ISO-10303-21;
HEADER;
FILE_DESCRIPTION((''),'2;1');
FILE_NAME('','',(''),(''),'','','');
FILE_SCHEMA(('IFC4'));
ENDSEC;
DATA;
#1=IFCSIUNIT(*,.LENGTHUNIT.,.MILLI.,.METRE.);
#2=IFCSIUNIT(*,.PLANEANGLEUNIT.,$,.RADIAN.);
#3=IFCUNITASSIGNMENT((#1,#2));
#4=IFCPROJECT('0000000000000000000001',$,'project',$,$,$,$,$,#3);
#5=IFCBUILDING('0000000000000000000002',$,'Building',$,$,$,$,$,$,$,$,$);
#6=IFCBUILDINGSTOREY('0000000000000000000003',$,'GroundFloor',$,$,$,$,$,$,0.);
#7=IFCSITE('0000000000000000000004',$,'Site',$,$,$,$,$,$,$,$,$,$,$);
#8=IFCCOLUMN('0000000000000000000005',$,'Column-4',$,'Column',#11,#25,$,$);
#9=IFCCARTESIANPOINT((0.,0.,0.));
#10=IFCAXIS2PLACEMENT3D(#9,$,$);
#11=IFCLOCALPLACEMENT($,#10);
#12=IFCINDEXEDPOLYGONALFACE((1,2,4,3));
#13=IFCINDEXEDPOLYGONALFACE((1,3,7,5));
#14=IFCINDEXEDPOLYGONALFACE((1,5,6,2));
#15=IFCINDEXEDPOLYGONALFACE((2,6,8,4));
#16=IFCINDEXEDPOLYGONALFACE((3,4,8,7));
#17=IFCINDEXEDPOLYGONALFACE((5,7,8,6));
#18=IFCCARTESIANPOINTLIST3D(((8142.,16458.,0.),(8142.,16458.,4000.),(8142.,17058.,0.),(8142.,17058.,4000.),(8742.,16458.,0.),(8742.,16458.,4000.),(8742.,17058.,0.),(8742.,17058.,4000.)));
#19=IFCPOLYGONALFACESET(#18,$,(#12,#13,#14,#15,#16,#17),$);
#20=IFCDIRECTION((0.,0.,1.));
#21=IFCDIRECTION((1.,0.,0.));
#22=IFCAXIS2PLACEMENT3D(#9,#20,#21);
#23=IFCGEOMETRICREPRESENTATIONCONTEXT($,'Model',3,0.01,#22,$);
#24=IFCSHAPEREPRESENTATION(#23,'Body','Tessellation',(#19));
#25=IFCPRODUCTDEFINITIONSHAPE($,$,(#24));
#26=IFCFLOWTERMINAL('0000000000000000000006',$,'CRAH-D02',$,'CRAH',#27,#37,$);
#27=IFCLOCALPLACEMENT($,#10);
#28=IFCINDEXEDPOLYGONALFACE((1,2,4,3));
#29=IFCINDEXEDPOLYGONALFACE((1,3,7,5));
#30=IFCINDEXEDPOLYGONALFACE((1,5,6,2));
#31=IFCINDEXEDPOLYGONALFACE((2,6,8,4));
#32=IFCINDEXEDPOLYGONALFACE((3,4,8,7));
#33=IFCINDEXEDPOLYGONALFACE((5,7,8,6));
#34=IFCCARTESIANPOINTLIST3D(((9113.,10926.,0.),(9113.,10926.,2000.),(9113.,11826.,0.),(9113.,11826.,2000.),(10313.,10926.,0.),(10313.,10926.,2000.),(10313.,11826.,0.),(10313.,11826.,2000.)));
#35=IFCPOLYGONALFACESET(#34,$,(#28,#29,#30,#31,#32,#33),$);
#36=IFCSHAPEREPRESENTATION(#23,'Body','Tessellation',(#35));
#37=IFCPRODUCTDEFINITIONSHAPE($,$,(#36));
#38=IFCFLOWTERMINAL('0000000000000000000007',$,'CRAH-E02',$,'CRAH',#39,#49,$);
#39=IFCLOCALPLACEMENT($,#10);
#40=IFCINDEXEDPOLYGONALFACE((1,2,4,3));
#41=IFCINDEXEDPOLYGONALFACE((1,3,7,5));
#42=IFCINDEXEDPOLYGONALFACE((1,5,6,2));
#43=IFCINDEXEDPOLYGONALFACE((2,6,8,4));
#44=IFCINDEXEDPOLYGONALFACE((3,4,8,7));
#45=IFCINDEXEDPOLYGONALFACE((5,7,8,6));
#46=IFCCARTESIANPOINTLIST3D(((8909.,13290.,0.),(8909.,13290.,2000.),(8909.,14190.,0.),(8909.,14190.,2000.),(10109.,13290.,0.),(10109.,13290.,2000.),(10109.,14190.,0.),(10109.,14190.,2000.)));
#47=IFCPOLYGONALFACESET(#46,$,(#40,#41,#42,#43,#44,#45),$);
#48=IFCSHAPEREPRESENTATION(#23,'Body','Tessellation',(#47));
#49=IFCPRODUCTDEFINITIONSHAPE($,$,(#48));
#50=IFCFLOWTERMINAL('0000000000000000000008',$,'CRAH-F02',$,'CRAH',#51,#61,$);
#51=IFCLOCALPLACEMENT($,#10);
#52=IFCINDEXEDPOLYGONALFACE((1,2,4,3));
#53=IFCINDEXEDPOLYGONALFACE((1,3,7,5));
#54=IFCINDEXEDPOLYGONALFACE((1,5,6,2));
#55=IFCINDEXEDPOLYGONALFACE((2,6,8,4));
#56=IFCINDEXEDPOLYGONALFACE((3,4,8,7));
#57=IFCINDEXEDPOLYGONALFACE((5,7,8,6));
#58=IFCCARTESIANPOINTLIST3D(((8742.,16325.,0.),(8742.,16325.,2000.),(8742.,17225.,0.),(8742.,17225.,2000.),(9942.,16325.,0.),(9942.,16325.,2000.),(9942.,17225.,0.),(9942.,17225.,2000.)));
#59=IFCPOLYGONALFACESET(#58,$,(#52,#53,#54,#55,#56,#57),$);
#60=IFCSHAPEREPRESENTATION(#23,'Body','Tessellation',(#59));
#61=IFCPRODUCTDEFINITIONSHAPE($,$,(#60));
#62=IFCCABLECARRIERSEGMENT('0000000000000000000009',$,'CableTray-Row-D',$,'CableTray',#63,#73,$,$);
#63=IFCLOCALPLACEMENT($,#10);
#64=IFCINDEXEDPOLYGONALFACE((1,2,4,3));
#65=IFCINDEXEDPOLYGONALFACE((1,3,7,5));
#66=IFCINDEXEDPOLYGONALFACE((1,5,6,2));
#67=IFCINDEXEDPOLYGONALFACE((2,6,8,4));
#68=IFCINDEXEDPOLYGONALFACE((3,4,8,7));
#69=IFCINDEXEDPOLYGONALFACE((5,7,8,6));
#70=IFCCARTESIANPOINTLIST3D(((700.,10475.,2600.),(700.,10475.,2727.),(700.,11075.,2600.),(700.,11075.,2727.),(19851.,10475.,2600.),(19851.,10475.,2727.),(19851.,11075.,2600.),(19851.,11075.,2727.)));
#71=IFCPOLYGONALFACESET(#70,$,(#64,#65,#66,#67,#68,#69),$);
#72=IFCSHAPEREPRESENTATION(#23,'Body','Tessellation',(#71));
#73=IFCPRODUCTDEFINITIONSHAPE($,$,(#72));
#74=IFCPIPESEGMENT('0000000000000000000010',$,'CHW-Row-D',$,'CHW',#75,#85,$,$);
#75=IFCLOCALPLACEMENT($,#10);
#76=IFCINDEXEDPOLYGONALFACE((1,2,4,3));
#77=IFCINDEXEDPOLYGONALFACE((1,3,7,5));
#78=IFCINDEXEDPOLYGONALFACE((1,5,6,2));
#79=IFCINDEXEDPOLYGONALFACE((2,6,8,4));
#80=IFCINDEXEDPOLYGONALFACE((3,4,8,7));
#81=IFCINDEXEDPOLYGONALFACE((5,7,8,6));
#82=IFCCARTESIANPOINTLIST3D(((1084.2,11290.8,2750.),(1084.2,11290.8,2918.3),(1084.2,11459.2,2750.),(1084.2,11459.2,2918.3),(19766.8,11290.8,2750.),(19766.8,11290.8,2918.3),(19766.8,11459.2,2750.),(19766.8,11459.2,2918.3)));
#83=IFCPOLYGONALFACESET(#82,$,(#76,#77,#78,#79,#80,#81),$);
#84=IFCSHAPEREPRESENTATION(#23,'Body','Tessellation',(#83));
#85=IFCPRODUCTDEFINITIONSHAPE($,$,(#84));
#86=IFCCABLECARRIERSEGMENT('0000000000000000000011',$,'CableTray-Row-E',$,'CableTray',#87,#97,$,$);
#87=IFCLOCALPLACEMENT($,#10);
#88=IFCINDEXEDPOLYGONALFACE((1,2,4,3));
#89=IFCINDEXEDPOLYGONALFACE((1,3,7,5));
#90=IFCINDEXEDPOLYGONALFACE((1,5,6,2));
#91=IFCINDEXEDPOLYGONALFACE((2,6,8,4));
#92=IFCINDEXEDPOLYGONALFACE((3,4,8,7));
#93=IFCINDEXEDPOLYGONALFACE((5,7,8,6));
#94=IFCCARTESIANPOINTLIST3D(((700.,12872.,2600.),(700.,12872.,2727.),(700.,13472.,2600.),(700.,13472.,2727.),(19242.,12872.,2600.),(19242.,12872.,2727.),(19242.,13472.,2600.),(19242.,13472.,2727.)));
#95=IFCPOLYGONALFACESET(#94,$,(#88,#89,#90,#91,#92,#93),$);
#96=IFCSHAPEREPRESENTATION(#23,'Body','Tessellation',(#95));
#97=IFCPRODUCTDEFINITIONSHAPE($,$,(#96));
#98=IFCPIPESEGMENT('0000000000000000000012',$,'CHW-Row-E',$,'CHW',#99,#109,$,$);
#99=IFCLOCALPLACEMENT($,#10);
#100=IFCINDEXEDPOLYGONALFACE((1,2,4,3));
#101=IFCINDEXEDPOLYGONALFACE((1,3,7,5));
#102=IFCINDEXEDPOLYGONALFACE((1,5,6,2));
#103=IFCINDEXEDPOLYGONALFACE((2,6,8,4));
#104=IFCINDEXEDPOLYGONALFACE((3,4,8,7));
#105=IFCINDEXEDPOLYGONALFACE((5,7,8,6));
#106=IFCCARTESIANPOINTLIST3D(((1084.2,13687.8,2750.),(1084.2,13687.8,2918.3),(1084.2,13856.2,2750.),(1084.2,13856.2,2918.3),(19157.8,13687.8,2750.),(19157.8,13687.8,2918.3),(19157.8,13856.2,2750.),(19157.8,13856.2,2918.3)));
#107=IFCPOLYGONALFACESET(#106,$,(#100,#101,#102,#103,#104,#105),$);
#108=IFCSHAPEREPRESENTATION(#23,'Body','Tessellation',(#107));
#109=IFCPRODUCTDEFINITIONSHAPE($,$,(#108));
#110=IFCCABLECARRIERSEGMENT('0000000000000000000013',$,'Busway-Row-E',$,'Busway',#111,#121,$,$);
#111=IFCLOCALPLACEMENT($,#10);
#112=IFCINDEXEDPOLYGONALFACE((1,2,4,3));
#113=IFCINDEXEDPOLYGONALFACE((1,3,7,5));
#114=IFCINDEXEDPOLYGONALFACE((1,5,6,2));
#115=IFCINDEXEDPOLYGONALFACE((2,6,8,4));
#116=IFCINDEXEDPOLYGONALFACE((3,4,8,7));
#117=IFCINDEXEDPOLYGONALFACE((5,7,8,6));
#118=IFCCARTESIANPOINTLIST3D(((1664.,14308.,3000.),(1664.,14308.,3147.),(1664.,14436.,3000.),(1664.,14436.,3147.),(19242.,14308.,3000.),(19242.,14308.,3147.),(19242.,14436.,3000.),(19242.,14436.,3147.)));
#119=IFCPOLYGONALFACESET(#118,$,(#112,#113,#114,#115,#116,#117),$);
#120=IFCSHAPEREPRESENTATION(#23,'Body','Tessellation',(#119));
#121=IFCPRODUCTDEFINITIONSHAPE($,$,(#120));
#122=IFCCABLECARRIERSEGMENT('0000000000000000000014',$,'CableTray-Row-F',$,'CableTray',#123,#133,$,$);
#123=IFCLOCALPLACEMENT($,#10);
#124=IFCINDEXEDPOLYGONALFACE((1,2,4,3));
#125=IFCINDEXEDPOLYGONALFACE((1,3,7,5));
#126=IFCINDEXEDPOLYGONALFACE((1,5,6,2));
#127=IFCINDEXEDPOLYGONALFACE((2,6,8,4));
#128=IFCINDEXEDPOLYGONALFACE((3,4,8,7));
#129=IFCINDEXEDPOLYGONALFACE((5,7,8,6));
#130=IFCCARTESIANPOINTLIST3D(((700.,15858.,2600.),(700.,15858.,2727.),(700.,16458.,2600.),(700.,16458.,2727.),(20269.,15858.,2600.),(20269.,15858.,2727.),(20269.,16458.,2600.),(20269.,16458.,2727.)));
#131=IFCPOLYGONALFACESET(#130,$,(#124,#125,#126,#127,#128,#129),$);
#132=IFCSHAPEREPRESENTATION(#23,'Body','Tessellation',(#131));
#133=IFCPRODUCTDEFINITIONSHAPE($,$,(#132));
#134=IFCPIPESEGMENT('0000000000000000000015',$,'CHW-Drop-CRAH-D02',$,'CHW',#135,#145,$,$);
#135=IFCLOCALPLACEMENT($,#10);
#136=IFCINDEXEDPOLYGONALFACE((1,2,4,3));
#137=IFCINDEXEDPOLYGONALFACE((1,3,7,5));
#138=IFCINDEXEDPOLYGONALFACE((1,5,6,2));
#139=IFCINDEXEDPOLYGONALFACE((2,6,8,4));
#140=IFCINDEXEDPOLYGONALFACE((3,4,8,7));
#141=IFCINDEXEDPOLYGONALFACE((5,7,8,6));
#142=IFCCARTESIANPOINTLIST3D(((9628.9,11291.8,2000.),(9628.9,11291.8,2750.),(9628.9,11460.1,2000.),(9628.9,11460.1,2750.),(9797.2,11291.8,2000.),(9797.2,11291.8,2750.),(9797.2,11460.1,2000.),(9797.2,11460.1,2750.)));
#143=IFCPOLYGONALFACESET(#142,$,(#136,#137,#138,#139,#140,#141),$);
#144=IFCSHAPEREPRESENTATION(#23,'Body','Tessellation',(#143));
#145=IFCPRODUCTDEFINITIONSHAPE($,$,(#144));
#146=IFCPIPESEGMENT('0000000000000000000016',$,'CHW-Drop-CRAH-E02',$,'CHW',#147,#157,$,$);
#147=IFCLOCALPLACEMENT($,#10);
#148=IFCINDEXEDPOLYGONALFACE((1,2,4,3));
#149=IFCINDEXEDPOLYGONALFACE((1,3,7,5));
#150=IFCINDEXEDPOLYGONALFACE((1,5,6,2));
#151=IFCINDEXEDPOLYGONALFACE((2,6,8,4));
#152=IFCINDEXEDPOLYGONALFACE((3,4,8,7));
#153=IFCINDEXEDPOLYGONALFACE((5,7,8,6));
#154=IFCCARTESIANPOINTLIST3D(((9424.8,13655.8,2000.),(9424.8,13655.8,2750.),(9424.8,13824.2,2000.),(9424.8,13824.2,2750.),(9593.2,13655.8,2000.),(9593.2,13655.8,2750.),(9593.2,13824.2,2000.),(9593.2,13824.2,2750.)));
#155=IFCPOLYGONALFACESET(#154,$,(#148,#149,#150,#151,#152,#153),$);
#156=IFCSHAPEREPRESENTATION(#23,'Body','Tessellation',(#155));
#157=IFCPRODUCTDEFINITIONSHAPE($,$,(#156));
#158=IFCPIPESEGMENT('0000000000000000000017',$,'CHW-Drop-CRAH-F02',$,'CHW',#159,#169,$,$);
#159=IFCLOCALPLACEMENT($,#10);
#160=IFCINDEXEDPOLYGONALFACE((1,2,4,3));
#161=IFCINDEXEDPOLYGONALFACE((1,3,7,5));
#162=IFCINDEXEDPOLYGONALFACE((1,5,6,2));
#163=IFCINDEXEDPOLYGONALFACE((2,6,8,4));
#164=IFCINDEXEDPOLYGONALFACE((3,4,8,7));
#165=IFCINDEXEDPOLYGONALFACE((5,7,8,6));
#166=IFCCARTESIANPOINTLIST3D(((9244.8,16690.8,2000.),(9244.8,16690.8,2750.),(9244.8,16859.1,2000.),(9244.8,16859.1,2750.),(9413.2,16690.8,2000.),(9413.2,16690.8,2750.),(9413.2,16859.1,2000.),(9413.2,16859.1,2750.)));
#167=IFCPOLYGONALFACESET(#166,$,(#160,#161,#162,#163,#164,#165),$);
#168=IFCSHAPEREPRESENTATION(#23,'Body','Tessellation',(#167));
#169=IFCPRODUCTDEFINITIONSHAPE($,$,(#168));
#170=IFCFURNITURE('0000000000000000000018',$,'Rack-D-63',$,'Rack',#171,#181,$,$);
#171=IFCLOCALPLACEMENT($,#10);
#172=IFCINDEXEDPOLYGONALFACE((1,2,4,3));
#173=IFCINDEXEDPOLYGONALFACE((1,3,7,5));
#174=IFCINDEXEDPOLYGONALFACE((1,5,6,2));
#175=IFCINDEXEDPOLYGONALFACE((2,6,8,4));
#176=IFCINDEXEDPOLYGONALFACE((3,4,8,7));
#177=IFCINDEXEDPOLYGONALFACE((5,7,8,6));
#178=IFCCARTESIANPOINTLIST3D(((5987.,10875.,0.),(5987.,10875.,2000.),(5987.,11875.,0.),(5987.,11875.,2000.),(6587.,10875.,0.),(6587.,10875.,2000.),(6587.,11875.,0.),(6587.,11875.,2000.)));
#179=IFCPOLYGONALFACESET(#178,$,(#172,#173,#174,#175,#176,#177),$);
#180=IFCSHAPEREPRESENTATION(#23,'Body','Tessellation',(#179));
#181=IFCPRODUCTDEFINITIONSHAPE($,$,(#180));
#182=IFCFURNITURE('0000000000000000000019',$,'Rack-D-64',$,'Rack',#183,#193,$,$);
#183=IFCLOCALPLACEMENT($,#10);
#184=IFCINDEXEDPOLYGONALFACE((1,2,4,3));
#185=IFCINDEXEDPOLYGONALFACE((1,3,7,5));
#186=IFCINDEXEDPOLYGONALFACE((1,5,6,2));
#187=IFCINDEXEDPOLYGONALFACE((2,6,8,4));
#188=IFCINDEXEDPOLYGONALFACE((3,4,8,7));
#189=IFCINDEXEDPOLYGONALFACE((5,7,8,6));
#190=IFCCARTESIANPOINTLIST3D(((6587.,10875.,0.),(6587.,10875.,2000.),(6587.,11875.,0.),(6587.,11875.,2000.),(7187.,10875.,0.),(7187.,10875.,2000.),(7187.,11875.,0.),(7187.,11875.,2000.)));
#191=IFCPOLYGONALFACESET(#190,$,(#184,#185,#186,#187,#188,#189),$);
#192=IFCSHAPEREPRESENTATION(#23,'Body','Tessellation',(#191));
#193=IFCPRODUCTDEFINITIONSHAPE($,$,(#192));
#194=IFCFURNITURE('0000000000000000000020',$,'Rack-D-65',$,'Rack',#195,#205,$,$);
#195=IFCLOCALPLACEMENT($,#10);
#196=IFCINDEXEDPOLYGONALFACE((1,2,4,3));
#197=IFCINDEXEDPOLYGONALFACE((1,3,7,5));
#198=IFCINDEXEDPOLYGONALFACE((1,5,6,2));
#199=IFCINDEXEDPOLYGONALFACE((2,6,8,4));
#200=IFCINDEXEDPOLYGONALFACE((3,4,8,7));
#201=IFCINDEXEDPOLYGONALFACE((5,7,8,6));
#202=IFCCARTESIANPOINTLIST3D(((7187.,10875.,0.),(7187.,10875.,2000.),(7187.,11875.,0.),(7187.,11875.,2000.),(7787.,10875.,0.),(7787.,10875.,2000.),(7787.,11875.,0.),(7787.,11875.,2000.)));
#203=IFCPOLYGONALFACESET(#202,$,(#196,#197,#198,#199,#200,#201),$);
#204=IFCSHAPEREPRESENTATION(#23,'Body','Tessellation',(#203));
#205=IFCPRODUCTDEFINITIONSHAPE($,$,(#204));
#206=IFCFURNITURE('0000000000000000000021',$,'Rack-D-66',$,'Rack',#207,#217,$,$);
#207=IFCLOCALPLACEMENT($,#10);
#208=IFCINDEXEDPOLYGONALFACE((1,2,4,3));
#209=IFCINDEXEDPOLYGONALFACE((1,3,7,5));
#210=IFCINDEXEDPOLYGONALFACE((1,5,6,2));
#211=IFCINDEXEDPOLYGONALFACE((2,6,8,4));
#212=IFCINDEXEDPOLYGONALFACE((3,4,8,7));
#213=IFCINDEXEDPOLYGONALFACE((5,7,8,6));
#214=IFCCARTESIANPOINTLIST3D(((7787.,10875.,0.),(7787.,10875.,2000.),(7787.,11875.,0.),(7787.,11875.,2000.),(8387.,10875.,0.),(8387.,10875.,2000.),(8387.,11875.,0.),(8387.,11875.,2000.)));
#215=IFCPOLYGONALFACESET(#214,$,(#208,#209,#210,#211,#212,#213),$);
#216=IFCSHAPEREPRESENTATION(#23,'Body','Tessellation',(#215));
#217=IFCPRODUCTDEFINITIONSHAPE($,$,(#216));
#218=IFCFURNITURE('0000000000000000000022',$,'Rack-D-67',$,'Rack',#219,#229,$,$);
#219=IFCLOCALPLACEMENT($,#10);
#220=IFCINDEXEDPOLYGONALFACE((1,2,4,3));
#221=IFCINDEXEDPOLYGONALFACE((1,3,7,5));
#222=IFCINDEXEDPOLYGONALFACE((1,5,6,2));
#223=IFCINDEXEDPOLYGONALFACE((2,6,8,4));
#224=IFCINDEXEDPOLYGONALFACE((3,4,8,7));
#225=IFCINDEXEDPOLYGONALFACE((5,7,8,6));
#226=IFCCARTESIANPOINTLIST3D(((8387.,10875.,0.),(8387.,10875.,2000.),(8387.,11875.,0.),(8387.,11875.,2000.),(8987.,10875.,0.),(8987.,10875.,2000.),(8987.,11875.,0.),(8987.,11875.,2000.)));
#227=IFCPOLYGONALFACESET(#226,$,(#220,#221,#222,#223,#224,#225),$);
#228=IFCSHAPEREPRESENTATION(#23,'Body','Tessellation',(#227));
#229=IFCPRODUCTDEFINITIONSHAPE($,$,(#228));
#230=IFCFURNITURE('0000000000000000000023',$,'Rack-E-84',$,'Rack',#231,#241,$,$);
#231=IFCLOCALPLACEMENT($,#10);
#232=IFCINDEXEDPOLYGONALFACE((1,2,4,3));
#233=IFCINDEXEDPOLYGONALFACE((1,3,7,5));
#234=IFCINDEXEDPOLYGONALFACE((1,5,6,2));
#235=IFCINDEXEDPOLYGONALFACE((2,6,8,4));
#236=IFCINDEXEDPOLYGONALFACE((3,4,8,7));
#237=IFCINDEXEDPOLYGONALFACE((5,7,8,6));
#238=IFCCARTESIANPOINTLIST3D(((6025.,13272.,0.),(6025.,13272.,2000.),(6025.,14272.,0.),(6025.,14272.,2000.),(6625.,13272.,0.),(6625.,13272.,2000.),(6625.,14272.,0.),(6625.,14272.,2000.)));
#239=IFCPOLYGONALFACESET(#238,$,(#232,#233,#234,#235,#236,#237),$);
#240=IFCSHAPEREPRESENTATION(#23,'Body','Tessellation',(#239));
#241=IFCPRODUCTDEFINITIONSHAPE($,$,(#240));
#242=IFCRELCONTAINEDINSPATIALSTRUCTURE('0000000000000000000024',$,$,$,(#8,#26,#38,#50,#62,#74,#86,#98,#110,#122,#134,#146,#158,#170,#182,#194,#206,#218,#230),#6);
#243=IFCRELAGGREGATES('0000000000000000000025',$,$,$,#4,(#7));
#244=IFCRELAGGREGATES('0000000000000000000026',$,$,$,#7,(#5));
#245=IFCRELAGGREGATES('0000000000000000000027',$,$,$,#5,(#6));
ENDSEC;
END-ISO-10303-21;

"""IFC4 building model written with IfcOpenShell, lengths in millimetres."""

from ifc_helpers import new_model, si_unit, frame, origin, origin_with_axes, origin_2d, place, context, project, spatial, rectangle, extrude, element, save


model = new_model("IFC4")

# Units and contexts
model_context = context("Model", 3, precision=0.01, world=origin_with_axes())
ifc_project = project(units=[si_unit("LENGTHUNIT", "METRE", prefix="MILLI"), si_unit("PLANEANGLEUNIT", "RADIAN")])

# Site, building, storey
site = spatial("IfcSite", under=ifc_project, Name="Site")
building = spatial("IfcBuilding", under=site, Name="Building")
storey = spatial("IfcBuildingStorey", under=building, Name="GroundFloor", Elevation=0.0)

# Column
column_placement = place(None, frame((8442.0, 16758.0, 0.0), z_axis=(0.0, 0.0, 1.0), x_axis=(1.0, 0.0, 0.0)))
element("IfcColumn", 1, at=column_placement, inside=storey, Name="Column-4", ObjectType="Column", context=model_context, shape_type="SweptSolid", body=[
    extrude(rectangle(XDim=600.0, YDim=600.0, at=origin_2d()), origin(), (0.0, 0.0, 1.0), 4000.0),
])

# Flow terminals
for number, where, z_axis, x_axis, name in (
    (2, (9713.0, 11376.0, 0.0), (0.0, 0.0, 1.0), (1.0, 0.0, 0.0), "CRAH-D02"),
    (3, (9509.0, 13740.0, 0.0), (0.0, 0.0, 1.0), (1.0, 0.0, 0.0), "CRAH-E02"),
    (4, (9342.0, 16775.0, 0.0), (0.0, 0.0, 1.0), (1.0, 0.0, 0.0), "CRAH-F02"),
):
    element("IfcFlowTerminal", number, at=place(None, frame(where, z_axis=z_axis, x_axis=x_axis)), inside=storey, Name=name, ObjectType="CRAH", context=model_context, shape_type="SweptSolid", body=[
        extrude(rectangle(XDim=1200.0, YDim=900.0, at=origin_2d()), origin(), (0.0, 0.0, 1.0), 2000.0),
    ])

# Cable carrier segment
cable_carrier_segment_1_placement = place(None, frame((10275.5, 10775.0, 2600.0), z_axis=(0.0, 0.0, 1.0), x_axis=(1.0, 0.0, 0.0)))
element("IfcCableCarrierSegment", 5, at=cable_carrier_segment_1_placement, inside=storey, Name="CableTray-Row-D", ObjectType="CableTray", context=model_context, shape_type="SweptSolid", body=[
    extrude(rectangle(XDim=19151.0, YDim=600.0, at=origin_2d()), origin(), (0.0, 0.0, 1.0), 127.0),
])

# Pipe segment
pipe_segment_1_placement = place(None, frame((10425.5, 11375.0, 2750.0), z_axis=(0.0, 0.0, 1.0), x_axis=(1.0, 0.0, 0.0)))
element("IfcPipeSegment", 6, at=pipe_segment_1_placement, inside=storey, Name="CHW-Row-D", ObjectType="CHW", context=model_context, shape_type="SweptSolid", body=[
    extrude(rectangle(XDim=18682.7, YDim=168.3, at=origin_2d()), origin(), (0.0, 0.0, 1.0), 168.3),
])

# Cable carrier segment
cable_carrier_segment_2_placement = place(None, frame((9971.0, 13172.0, 2600.0), z_axis=(0.0, 0.0, 1.0), x_axis=(1.0, 0.0, 0.0)))
element("IfcCableCarrierSegment", 7, at=cable_carrier_segment_2_placement, inside=storey, Name="CableTray-Row-E", ObjectType="CableTray", context=model_context, shape_type="SweptSolid", body=[
    extrude(rectangle(XDim=18542.0, YDim=600.0, at=origin_2d()), origin(), (0.0, 0.0, 1.0), 127.0),
])

# Pipe segment
pipe_segment_2_placement = place(None, frame((10121.0, 13772.0, 2750.0), z_axis=(0.0, 0.0, 1.0), x_axis=(1.0, 0.0, 0.0)))
element("IfcPipeSegment", 8, at=pipe_segment_2_placement, inside=storey, Name="CHW-Row-E", ObjectType="CHW", context=model_context, shape_type="SweptSolid", body=[
    extrude(rectangle(XDim=18073.7, YDim=168.3, at=origin_2d()), origin(), (0.0, 0.0, 1.0), 168.3),
])

# Cable carrier segments
cable_carrier_segment_3_placement = place(None, frame((10453.0, 14372.0, 3000.0), z_axis=(0.0, 0.0, 1.0), x_axis=(1.0, 0.0, 0.0)))
element("IfcCableCarrierSegment", 9, at=cable_carrier_segment_3_placement, inside=storey, Name="Busway-Row-E", ObjectType="Busway", context=model_context, shape_type="SweptSolid", body=[
    extrude(rectangle(XDim=17578.0, YDim=128.0, at=origin_2d()), origin(), (0.0, 0.0, 1.0), 147.0),
])
cable_carrier_segment_4_placement = place(None, frame((10484.5, 16158.0, 2600.0), z_axis=(0.0, 0.0, 1.0), x_axis=(1.0, 0.0, 0.0)))
element("IfcCableCarrierSegment", 10, at=cable_carrier_segment_4_placement, inside=storey, Name="CableTray-Row-F", ObjectType="CableTray", context=model_context, shape_type="SweptSolid", body=[
    extrude(rectangle(XDim=19569.0, YDim=600.0, at=origin_2d()), origin(), (0.0, 0.0, 1.0), 127.0),
])

# Pipe segments
for number, where, z_axis, x_axis, name in (
    (11, (9713.0, 11376.0, 2000.0), (0.0, 0.0, 1.0), (1.0, 0.0, 0.0), "CHW-Drop-CRAH-D02"),
    (12, (9509.0, 13740.0, 2000.0), (0.0, 0.0, 1.0), (1.0, 0.0, 0.0), "CHW-Drop-CRAH-E02"),
    (13, (9329.0, 16775.0, 2000.0), (0.0, 0.0, 1.0), (1.0, 0.0, 0.0), "CHW-Drop-CRAH-F02"),
):
    element("IfcPipeSegment", number, at=place(None, frame(where, z_axis=z_axis, x_axis=x_axis)), inside=storey, Name=name, ObjectType="CHW", context=model_context, shape_type="SweptSolid", body=[
        extrude(rectangle(XDim=168.3, YDim=168.3, at=origin_2d()), origin(), (0.0, 0.0, 1.0), 750.0),
    ])

# Furniture
for number, where, z_axis, x_axis, name in (
    (14, (6287.0, 11375.0, 0.0), (0.0, 0.0, 1.0), (1.0, 0.0, 0.0), "Rack-D-63"),
    (15, (6887.0, 11375.0, 0.0), (0.0, 0.0, 1.0), (1.0, 0.0, 0.0), "Rack-D-64"),
    (16, (7487.0, 11375.0, 0.0), (0.0, 0.0, 1.0), (1.0, 0.0, 0.0), "Rack-D-65"),
    (17, (8087.0, 11375.0, 0.0), (0.0, 0.0, 1.0), (1.0, 0.0, 0.0), "Rack-D-66"),
    (18, (8687.0, 11375.0, 0.0), (0.0, 0.0, 1.0), (1.0, 0.0, 0.0), "Rack-D-67"),
    (19, (6325.0, 13772.0, 0.0), (0.0, 0.0, 1.0), (1.0, 0.0, 0.0), "Rack-E-84"),
):
    element("IfcFurniture", number, at=place(None, frame(where, z_axis=z_axis, x_axis=x_axis)), inside=storey, Name=name, ObjectType="Rack", context=model_context, shape_type="SweptSolid", body=[
        extrude(rectangle(XDim=600.0, YDim=1000.0, at=origin_2d()), origin(), (0.0, 0.0, 1.0), 2000.0),
    ])

save(model, "model.ifc")
